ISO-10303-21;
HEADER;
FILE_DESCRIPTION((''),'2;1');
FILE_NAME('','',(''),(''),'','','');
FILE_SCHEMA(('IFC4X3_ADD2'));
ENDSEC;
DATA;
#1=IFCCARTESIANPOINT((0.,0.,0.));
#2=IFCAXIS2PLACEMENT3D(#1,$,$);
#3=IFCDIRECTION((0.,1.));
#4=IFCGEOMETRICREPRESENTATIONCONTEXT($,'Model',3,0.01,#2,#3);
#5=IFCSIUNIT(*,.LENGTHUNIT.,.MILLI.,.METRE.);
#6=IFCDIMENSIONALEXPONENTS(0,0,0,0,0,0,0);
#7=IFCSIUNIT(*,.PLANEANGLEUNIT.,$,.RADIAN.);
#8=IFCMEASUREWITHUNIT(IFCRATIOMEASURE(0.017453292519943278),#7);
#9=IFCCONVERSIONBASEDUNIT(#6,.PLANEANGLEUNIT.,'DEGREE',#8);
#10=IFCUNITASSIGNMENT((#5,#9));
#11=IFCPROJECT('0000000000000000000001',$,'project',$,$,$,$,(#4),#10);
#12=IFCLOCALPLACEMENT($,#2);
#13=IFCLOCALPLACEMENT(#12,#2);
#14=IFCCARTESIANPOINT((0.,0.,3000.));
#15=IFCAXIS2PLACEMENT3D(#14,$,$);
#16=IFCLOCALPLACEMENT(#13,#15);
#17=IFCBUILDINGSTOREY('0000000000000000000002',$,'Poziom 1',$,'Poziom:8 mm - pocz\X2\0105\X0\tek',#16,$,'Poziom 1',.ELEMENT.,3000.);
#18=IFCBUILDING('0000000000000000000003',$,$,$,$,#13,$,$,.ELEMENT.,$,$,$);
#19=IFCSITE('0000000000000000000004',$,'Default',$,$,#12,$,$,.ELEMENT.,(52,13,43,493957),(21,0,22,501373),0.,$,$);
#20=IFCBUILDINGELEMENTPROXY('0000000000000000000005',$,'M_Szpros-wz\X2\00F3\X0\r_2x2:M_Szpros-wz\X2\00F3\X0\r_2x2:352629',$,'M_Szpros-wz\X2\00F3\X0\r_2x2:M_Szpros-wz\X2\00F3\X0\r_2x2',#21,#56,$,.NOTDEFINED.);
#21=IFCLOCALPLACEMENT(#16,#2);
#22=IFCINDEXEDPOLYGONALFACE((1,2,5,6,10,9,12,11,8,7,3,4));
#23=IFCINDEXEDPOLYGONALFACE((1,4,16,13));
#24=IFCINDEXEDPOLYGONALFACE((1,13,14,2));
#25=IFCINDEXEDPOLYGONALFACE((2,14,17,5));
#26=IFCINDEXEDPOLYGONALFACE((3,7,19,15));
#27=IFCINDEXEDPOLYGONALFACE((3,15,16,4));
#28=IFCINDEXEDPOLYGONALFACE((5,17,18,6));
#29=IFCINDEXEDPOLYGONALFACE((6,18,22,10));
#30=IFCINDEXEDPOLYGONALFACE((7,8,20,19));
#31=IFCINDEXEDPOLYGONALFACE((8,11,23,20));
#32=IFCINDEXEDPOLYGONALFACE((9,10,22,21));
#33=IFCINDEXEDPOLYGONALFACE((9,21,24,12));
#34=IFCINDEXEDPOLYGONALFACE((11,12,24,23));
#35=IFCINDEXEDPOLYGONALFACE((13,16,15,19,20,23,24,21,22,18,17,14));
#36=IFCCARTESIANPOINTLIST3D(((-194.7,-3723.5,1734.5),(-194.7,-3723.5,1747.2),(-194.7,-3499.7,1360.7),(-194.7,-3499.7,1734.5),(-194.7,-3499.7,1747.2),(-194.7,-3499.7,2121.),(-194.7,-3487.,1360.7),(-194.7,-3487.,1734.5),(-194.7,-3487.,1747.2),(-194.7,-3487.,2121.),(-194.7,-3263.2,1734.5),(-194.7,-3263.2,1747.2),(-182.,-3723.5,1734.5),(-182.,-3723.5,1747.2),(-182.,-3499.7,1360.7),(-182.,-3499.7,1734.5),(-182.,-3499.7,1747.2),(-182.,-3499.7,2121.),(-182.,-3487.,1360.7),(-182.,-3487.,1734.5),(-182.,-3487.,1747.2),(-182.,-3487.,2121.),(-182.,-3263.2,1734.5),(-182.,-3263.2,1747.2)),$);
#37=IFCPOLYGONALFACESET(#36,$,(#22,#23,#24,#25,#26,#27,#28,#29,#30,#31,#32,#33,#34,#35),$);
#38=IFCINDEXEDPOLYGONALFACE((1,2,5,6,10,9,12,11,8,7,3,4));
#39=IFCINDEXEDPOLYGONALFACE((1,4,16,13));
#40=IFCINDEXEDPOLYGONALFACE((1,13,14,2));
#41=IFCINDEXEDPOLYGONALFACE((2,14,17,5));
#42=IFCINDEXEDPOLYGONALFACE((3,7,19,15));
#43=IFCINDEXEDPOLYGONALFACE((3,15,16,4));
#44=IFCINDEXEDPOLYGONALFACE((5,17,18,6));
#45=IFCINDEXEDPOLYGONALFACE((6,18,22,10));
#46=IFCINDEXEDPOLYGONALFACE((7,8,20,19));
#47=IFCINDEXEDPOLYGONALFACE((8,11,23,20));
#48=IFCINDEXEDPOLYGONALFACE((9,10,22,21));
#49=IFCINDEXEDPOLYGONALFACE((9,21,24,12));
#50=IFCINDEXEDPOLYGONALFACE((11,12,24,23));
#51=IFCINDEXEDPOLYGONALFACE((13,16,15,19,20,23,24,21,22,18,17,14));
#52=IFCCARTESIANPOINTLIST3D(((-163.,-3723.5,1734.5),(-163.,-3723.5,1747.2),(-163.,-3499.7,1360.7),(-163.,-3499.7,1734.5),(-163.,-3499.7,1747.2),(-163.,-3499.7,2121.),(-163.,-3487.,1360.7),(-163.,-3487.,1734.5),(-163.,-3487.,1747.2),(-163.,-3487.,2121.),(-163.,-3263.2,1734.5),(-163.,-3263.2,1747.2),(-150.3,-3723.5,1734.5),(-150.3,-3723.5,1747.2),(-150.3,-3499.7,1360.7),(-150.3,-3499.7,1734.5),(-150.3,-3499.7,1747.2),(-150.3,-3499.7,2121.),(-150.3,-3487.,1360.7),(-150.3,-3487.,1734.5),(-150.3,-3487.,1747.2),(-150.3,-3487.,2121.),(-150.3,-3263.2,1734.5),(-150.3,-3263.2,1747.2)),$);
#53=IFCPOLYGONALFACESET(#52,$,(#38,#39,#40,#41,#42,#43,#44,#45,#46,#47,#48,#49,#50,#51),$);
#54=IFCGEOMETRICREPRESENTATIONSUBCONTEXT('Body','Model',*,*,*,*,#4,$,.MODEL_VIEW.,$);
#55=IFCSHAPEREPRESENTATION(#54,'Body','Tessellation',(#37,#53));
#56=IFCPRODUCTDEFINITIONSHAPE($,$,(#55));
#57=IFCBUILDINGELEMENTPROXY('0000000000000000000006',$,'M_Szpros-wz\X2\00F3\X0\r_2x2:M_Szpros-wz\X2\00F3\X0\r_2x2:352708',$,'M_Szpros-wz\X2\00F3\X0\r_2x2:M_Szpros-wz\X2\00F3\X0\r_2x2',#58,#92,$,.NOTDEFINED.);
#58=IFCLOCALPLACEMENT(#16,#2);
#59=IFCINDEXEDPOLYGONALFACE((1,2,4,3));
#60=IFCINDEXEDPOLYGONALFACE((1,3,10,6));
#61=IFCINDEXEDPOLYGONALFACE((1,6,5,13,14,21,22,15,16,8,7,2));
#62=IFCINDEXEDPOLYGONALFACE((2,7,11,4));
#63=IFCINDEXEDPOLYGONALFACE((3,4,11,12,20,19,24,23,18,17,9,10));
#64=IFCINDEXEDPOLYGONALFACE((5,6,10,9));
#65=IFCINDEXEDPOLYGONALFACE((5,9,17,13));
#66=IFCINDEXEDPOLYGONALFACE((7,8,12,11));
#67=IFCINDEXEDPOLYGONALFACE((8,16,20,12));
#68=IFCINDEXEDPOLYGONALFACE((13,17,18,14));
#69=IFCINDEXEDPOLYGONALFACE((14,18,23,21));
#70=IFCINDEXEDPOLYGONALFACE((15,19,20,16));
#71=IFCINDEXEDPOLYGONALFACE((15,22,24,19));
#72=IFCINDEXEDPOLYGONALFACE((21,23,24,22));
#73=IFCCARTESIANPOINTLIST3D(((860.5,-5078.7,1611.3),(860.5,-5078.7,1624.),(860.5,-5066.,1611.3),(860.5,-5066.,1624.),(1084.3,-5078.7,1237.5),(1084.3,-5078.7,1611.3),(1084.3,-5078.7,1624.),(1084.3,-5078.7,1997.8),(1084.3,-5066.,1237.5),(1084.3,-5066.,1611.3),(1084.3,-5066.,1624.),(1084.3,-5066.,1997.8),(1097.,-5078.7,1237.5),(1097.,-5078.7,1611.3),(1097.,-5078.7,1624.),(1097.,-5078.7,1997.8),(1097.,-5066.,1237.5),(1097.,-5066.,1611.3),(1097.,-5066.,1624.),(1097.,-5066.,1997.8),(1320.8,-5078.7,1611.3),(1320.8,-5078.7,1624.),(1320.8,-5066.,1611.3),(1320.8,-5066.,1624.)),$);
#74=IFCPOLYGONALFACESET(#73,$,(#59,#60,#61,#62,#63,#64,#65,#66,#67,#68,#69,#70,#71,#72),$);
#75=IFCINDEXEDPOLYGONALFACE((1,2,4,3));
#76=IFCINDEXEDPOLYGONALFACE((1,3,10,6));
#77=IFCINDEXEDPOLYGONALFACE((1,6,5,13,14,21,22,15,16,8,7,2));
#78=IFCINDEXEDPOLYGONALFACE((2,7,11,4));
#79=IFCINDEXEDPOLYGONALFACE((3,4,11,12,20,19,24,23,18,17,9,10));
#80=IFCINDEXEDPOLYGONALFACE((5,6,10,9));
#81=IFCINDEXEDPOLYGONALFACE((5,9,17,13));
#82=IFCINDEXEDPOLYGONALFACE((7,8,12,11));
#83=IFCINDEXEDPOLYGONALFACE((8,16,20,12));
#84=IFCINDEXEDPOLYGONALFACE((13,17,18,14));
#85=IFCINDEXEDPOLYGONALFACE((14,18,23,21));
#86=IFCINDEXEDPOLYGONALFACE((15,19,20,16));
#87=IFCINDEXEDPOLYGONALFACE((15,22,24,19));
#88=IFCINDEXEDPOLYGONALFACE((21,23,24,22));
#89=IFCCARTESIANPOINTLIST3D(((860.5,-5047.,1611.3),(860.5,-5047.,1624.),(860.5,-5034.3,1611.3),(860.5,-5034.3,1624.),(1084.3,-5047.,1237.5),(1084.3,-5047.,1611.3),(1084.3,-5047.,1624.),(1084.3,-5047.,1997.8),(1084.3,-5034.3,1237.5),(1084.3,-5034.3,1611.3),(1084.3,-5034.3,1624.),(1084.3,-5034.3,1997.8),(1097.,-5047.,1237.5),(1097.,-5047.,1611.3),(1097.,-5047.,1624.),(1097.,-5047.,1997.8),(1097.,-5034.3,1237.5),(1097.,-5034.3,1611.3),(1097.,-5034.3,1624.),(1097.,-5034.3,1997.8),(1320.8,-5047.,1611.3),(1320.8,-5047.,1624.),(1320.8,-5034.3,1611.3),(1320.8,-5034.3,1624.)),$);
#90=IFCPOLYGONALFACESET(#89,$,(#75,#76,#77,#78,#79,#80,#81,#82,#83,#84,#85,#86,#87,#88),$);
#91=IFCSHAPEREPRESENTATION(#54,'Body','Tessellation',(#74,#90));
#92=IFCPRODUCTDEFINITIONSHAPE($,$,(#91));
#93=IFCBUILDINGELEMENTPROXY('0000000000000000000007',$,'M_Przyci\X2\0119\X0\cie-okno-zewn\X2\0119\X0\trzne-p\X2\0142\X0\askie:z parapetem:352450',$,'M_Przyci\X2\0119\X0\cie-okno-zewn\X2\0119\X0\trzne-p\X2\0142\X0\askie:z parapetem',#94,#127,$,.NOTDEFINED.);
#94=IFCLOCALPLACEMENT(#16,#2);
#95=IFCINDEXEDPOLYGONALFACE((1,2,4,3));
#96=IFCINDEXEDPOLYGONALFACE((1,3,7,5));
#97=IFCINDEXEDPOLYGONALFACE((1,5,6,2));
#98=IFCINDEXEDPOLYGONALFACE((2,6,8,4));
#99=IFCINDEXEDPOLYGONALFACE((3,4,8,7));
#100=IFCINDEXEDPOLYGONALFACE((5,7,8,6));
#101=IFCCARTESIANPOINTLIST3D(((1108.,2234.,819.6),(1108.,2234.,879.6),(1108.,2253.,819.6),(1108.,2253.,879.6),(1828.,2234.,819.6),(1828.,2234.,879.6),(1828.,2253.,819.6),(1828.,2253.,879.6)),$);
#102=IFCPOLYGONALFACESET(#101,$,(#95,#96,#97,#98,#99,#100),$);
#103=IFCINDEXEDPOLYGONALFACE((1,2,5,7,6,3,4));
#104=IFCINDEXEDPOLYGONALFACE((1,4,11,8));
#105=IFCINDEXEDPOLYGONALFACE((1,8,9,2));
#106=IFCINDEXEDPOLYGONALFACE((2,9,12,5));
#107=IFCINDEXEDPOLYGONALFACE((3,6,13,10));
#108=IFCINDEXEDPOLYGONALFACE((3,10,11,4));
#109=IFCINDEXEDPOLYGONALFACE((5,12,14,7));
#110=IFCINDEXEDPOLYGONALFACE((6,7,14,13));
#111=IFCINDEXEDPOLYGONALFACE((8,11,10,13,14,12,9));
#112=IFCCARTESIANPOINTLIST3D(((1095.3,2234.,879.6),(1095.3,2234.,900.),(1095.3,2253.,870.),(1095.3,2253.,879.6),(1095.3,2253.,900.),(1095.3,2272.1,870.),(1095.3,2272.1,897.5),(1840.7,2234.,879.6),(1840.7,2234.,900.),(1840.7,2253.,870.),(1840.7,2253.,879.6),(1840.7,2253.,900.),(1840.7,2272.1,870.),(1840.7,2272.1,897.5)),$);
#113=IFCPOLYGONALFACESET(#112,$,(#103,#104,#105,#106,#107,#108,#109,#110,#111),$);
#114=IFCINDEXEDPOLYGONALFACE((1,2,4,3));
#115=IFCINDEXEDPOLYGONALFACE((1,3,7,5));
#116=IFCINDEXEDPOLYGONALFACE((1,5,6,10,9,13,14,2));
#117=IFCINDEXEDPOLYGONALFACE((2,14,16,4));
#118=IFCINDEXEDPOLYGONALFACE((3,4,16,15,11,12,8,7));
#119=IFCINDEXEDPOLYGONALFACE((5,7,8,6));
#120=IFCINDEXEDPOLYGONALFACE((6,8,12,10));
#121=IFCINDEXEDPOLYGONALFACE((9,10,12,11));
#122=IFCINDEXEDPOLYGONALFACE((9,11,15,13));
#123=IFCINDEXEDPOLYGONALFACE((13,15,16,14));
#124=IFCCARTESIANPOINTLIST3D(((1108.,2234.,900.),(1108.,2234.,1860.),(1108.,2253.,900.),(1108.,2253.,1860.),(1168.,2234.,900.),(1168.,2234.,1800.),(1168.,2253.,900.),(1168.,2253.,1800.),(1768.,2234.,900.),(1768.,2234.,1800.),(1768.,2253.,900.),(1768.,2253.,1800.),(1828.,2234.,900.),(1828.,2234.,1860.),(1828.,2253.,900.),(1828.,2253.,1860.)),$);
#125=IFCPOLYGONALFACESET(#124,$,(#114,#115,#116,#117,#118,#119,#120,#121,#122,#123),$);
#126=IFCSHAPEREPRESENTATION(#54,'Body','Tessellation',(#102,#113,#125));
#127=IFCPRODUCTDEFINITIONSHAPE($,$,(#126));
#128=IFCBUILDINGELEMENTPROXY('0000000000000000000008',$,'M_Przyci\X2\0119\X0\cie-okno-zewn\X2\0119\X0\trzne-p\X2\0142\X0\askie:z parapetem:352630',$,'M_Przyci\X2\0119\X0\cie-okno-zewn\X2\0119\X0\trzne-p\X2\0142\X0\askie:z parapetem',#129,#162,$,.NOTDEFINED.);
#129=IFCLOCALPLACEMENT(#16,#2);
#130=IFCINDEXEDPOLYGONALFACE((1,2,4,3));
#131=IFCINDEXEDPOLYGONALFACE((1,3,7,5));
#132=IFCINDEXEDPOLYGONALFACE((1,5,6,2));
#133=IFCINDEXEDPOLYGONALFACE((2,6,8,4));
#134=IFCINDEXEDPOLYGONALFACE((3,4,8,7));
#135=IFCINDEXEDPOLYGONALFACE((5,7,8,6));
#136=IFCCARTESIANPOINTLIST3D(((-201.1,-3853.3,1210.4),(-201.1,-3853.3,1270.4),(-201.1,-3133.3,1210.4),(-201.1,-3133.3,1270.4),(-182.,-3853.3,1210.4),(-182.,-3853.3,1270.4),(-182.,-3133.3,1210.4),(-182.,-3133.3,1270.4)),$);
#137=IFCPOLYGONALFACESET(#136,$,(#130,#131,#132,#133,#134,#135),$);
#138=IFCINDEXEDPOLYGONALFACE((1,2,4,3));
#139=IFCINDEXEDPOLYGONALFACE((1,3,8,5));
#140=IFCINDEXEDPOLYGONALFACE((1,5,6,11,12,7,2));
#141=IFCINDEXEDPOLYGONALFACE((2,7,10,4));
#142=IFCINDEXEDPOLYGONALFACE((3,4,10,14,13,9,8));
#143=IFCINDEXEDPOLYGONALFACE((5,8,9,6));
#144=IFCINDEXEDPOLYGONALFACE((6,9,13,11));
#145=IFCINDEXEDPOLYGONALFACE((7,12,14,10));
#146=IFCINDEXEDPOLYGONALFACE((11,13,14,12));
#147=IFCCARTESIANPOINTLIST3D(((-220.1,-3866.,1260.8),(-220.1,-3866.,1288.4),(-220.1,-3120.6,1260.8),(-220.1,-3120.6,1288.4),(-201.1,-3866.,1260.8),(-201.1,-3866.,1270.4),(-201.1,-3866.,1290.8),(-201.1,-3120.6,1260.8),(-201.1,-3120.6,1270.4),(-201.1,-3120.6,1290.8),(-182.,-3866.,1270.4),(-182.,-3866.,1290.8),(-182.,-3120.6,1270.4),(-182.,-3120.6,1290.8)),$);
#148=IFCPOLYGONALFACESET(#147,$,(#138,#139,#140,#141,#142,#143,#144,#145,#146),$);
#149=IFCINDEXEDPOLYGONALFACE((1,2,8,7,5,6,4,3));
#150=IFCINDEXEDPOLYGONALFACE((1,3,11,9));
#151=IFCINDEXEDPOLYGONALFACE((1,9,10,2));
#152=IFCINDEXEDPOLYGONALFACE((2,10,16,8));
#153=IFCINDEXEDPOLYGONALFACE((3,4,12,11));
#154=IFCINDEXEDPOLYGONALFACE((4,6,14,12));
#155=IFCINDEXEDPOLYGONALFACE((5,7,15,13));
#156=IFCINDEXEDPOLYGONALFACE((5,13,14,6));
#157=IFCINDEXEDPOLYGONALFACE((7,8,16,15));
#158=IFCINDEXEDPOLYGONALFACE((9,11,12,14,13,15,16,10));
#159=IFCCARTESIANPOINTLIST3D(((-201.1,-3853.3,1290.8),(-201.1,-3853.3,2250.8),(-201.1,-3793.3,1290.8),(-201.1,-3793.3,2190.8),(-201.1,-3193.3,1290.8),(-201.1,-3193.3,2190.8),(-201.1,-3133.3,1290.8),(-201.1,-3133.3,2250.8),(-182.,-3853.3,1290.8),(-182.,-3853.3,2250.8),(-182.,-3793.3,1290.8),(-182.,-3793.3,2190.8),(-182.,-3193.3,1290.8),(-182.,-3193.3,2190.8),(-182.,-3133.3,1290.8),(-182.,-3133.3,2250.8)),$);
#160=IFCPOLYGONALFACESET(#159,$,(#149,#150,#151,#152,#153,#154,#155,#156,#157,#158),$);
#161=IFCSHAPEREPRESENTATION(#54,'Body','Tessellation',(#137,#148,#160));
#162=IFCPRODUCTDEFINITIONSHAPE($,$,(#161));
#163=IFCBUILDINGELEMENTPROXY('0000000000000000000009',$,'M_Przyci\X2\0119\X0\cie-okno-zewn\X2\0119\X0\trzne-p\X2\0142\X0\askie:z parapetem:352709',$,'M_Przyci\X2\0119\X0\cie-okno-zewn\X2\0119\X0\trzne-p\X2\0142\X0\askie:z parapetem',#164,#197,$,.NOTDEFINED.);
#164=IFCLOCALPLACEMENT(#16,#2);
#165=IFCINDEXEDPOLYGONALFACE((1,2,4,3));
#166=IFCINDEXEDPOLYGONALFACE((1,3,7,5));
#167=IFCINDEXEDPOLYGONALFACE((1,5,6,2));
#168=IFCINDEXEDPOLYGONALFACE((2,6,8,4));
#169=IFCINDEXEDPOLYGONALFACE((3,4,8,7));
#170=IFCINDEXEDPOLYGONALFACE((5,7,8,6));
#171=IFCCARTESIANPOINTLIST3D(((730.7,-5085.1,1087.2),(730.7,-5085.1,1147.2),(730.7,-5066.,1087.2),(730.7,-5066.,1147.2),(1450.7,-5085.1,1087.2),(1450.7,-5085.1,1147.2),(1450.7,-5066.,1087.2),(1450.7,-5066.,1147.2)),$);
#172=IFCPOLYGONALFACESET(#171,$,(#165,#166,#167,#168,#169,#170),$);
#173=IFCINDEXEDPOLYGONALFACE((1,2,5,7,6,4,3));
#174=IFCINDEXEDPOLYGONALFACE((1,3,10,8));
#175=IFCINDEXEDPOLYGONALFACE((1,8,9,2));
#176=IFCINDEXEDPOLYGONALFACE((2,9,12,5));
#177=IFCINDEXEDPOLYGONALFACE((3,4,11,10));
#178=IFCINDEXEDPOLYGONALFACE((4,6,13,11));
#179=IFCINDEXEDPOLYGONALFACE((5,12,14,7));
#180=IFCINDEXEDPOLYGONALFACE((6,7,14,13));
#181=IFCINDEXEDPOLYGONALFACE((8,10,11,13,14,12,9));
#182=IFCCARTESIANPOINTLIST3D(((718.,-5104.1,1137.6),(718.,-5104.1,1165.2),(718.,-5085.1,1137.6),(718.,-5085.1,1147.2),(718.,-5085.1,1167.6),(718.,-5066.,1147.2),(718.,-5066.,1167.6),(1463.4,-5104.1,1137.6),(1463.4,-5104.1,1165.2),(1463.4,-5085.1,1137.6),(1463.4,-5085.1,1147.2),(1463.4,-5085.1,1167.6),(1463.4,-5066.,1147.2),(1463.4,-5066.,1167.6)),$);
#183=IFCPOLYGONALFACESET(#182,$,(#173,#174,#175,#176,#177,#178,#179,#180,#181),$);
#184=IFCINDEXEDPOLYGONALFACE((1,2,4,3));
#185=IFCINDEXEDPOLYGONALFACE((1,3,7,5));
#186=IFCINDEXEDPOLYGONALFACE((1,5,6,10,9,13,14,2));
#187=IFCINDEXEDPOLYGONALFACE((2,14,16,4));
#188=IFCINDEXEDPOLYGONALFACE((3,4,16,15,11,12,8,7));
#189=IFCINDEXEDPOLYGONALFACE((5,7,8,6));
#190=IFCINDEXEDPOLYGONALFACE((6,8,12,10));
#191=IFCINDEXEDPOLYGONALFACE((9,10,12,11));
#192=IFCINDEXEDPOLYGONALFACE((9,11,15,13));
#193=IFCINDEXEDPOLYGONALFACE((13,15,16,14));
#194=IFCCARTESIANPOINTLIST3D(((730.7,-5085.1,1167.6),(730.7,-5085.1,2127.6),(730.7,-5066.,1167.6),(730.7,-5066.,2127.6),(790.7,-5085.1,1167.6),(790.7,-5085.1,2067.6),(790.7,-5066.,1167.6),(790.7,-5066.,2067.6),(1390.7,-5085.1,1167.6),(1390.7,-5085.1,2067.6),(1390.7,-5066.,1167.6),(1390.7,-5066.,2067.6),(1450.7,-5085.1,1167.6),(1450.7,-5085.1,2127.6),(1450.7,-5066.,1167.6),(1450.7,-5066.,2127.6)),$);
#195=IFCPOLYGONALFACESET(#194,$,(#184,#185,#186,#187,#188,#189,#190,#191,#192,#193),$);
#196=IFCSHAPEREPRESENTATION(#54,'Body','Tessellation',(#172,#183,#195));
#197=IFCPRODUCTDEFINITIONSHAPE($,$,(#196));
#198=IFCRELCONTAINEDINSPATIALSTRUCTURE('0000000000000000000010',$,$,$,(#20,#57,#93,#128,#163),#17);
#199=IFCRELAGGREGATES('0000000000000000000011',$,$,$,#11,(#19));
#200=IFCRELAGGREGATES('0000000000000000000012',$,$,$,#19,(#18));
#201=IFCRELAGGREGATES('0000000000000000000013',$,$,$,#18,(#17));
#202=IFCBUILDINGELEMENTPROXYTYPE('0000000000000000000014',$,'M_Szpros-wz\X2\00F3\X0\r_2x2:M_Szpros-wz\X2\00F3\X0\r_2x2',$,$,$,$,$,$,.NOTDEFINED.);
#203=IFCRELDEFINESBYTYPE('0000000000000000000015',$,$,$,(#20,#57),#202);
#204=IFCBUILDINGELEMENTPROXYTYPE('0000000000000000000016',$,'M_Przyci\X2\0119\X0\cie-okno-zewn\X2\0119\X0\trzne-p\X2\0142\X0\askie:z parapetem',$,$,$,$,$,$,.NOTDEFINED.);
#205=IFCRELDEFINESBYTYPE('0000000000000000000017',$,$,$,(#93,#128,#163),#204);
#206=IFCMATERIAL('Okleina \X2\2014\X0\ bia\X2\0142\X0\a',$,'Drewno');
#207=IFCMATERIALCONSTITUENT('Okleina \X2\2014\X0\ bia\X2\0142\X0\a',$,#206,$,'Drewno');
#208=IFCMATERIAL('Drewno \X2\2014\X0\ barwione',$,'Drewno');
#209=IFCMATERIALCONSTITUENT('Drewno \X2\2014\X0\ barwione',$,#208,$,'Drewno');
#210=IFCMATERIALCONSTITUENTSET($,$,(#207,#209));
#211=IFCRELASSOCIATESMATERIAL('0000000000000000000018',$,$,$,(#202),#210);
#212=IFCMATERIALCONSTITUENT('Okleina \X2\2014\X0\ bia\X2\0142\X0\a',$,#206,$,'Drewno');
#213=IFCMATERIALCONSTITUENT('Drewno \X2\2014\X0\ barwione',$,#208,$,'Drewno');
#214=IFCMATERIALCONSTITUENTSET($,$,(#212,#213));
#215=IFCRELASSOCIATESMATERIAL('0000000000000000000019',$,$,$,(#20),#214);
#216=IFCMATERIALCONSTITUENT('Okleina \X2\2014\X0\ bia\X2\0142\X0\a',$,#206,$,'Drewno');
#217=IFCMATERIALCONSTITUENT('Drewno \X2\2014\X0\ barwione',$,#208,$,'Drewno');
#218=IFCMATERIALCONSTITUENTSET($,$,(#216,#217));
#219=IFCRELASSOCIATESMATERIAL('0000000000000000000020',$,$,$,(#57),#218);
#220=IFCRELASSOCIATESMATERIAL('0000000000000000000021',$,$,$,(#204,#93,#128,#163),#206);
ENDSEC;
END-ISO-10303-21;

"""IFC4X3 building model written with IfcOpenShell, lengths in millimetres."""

from ifc_helpers import new_model, entity, si_unit, converted_unit, direction, frame, frame_2d, origin, place, context, subcontext, project, spatial, polyline, rectangle, outline, extrude, source, transform, mapped, material, constituent, constituent_set, type_object, type_shapes, element, save


model = new_model("IFC4X3")

# Units and contexts
model_context = context("Model", 3, precision=0.01, world=origin(), true_north=direction((0.0, 1.0)))
body_context = subcontext(model_context, "Body", "Model", "MODEL_VIEW")
ifc_project = project(units=[si_unit("LENGTHUNIT", "METRE", prefix="MILLI"), converted_unit("PLANEANGLEUNIT", "DEGREE", entity("IfcRatioMeasure", 0.017453292519943278), si_unit("PLANEANGLEUNIT", "RADIAN"), dimensions=[0, 0, 0, 0, 0, 0, 0])], contexts=[model_context])

# Site, building, storey
site_placement = place(None, origin())
site = spatial("IfcSite", under=ifc_project, at=site_placement, Name="Default", CompositionType="ELEMENT", RefLatitude=(52, 13, 43, 493957), RefLongitude=(21, 0, 22, 501373), RefElevation=0.0)
building_placement = place(site_placement, origin())
building = spatial("IfcBuilding", under=site, at=building_placement, CompositionType="ELEMENT")
storey_placement = place(building_placement, frame((0.0, 0.0, 3000.0)))
storey = spatial("IfcBuildingStorey", under=building, at=storey_placement, Name="Poziom 1", ObjectType="Poziom:8 mm - początek", LongName="Poziom 1", CompositionType="ELEMENT", Elevation=3000.0)

# Building element proxies
ifc_material_1 = material(Name="Okleina — biała", Category="Drewno")
ifc_material_2 = material(Name="Drewno — barwione", Category="Drewno")
ifc_constituent_1 = constituent(ifc_material_1, Name="Okleina — biała", Category="Drewno")
ifc_constituent_2 = constituent(ifc_material_2, Name="Drewno — barwione", Category="Drewno")
ifc_constituent_set_1 = constituent_set(constituents=[ifc_constituent_1, ifc_constituent_2])
building_element_proxy_type_1 = type_object("IfcBuildingElementProxyType", Name="M_Szpros-wzór_2x2:M_Szpros-wzór_2x2", PredefinedType="NOTDEFINED", material=ifc_constituent_set_1)
shared_shape_1 = source(origin(), body_context, "Body", "SweptSolid", [
    extrude(outline(polyline([(6.4, -6.4), (380.1, -6.4), (380.1, 6.3), (6.4, 6.3), (6.4, 230.2), (-6.3, 230.2), (-6.3, 6.3), (-380.2, 6.3), (-380.2, -6.4), (-6.3, -6.4), (-6.3, -230.1), (6.4, -230.1), (6.4, -6.4)])), frame((0.0, 9.5, 380.1), z_axis=(0.0, 1.0, 0.0), x_axis=(0.0, 0.0, 1.0)), (0.0, 0.0, 1.0), 12.7),
    extrude(outline(polyline([(6.4, -6.4), (380.2, -6.4), (380.2, 6.3), (6.4, 6.3), (6.4, 230.2), (-6.3, 230.2), (-6.3, 6.3), (-380.2, 6.3), (-380.2, -6.4), (-6.3, -6.4), (-6.3, -230.1), (6.4, -230.1), (6.4, -6.4)])), frame((0.0, -22.2, 380.2), z_axis=(0.0, 1.0, 0.0), x_axis=(0.0, 0.0, 1.0)), (0.0, 0.0, 1.0), 12.7),
])
type_shapes(building_element_proxy_type_1, [shared_shape_1])
ifc_constituent_3 = constituent(ifc_material_1, Name="Okleina — biała", Category="Drewno")
ifc_constituent_4 = constituent(ifc_material_2, Name="Drewno — barwione", Category="Drewno")
ifc_constituent_set_2 = constituent_set(constituents=[ifc_constituent_3, ifc_constituent_4])
proxy_1_placement = place(storey_placement, frame((-172.5, -3493.3, 1360.7), z_axis=(0.0, 0.0, 1.0), x_axis=(0.0, 1.0, 0.0)))
element("IfcBuildingElementProxy", 1, at=proxy_1_placement, inside=storey, type_object=building_element_proxy_type_1, material=ifc_constituent_set_2, Name="M_Szpros-wzór_2x2:M_Szpros-wzór_2x2:352629", ObjectType="M_Szpros-wzór_2x2:M_Szpros-wzór_2x2", PredefinedType="NOTDEFINED", context=body_context, shape_type="MappedRepresentation", body=[
    mapped(shared_shape_1, transform((0.0, 0.0, 0.0), scale=1.0)),
])
ifc_constituent_5 = constituent(ifc_material_1, Name="Okleina — biała", Category="Drewno")
ifc_constituent_6 = constituent(ifc_material_2, Name="Drewno — barwione", Category="Drewno")
ifc_constituent_set_3 = constituent_set(constituents=[ifc_constituent_5, ifc_constituent_6])
proxy_2_placement = place(storey_placement, frame((1090.7, -5056.5, 1237.5), z_axis=(0.0, 0.0, 1.0), x_axis=(-1.0, 0.0, 0.0)))
element("IfcBuildingElementProxy", 2, at=proxy_2_placement, inside=storey, type_object=building_element_proxy_type_1, material=ifc_constituent_set_3, Name="M_Szpros-wzór_2x2:M_Szpros-wzór_2x2:352708", ObjectType="M_Szpros-wzór_2x2:M_Szpros-wzór_2x2", PredefinedType="NOTDEFINED", context=body_context, shape_type="MappedRepresentation", body=[
    mapped(shared_shape_1, transform((0.0, 0.0, 0.0), scale=1.0)),
])
building_element_proxy_type_2 = type_object("IfcBuildingElementProxyType", Name="M_Przycięcie-okno-zewnętrzne-płaskie:z parapetem", PredefinedType="NOTDEFINED", material=ifc_material_1)
shared_shape_2 = source(origin(), body_context, "Body", "SweptSolid", [
    extrude(rectangle(XDim=720.0, YDim=60.0, at=frame_2d((0.0, 0.0), x_axis=(1.0, 0.0))), frame((0.0, -950.4, 0.0), z_axis=(0.0, 0.0, 1.0), x_axis=(-1.0, 0.0, 0.0)), (0.0, 0.0, 1.0), 19.0),
    extrude(outline(polyline([(-19.0, -15.2), (0.0, -15.2), (0.0, -5.7), (19.0, -5.7), (19.0, 14.8), (0.0, 14.8), (-19.0, 12.3), (-19.0, -15.2)])), frame((-372.7, -914.8, 19.0), z_axis=(1.0, 0.0, 0.0), x_axis=(0.0, 0.0, -1.0)), (0.0, 0.0, 1.0), 745.4),
    extrude(outline(polyline([(-495.0, -360.0), (465.0, -360.0), (465.0, -300.0), (-435.0, -300.0), (-435.0, 300.0), (465.0, 300.0), (465.0, 360.0), (-495.0, 360.0), (-495.0, -360.0)])), frame((0.0, -435.0, 0.0), z_axis=(0.0, 0.0, 1.0), x_axis=(0.0, -1.0, 0.0)), (0.0, 0.0, 1.0), 19.0),
])
type_shapes(building_element_proxy_type_2, [shared_shape_2])
for number, where, z_axis, x_axis, name in (
    (3, (1468.0, 2234.0, 1800.0), (0.0, 1.0, 0.0), (-1.0, 0.0, 0.0), "M_Przycięcie-okno-zewnętrzne-płaskie:z parapetem:352450"),
    (4, (-182.0, -3493.3, 2190.8), (-1.0, 0.0, 0.0), (0.0, -1.0, 0.0), "M_Przycięcie-okno-zewnętrzne-płaskie:z parapetem:352630"),
    (5, (1090.7, -5066.0, 2067.6), (0.0, -1.0, 0.0), (1.0, 0.0, 0.0), "M_Przycięcie-okno-zewnętrzne-płaskie:z parapetem:352709"),
):
    element("IfcBuildingElementProxy", number, at=place(storey_placement, frame(where, z_axis=z_axis, x_axis=x_axis)), inside=storey, type_object=building_element_proxy_type_2, material=ifc_material_1, Name=name, ObjectType="M_Przycięcie-okno-zewnętrzne-płaskie:z parapetem", PredefinedType="NOTDEFINED", context=body_context, shape_type="MappedRepresentation", body=[
        mapped(shared_shape_2, transform((0.0, 0.0, 0.0), scale=1.0)),
    ])

save(model, "model.ifc")
